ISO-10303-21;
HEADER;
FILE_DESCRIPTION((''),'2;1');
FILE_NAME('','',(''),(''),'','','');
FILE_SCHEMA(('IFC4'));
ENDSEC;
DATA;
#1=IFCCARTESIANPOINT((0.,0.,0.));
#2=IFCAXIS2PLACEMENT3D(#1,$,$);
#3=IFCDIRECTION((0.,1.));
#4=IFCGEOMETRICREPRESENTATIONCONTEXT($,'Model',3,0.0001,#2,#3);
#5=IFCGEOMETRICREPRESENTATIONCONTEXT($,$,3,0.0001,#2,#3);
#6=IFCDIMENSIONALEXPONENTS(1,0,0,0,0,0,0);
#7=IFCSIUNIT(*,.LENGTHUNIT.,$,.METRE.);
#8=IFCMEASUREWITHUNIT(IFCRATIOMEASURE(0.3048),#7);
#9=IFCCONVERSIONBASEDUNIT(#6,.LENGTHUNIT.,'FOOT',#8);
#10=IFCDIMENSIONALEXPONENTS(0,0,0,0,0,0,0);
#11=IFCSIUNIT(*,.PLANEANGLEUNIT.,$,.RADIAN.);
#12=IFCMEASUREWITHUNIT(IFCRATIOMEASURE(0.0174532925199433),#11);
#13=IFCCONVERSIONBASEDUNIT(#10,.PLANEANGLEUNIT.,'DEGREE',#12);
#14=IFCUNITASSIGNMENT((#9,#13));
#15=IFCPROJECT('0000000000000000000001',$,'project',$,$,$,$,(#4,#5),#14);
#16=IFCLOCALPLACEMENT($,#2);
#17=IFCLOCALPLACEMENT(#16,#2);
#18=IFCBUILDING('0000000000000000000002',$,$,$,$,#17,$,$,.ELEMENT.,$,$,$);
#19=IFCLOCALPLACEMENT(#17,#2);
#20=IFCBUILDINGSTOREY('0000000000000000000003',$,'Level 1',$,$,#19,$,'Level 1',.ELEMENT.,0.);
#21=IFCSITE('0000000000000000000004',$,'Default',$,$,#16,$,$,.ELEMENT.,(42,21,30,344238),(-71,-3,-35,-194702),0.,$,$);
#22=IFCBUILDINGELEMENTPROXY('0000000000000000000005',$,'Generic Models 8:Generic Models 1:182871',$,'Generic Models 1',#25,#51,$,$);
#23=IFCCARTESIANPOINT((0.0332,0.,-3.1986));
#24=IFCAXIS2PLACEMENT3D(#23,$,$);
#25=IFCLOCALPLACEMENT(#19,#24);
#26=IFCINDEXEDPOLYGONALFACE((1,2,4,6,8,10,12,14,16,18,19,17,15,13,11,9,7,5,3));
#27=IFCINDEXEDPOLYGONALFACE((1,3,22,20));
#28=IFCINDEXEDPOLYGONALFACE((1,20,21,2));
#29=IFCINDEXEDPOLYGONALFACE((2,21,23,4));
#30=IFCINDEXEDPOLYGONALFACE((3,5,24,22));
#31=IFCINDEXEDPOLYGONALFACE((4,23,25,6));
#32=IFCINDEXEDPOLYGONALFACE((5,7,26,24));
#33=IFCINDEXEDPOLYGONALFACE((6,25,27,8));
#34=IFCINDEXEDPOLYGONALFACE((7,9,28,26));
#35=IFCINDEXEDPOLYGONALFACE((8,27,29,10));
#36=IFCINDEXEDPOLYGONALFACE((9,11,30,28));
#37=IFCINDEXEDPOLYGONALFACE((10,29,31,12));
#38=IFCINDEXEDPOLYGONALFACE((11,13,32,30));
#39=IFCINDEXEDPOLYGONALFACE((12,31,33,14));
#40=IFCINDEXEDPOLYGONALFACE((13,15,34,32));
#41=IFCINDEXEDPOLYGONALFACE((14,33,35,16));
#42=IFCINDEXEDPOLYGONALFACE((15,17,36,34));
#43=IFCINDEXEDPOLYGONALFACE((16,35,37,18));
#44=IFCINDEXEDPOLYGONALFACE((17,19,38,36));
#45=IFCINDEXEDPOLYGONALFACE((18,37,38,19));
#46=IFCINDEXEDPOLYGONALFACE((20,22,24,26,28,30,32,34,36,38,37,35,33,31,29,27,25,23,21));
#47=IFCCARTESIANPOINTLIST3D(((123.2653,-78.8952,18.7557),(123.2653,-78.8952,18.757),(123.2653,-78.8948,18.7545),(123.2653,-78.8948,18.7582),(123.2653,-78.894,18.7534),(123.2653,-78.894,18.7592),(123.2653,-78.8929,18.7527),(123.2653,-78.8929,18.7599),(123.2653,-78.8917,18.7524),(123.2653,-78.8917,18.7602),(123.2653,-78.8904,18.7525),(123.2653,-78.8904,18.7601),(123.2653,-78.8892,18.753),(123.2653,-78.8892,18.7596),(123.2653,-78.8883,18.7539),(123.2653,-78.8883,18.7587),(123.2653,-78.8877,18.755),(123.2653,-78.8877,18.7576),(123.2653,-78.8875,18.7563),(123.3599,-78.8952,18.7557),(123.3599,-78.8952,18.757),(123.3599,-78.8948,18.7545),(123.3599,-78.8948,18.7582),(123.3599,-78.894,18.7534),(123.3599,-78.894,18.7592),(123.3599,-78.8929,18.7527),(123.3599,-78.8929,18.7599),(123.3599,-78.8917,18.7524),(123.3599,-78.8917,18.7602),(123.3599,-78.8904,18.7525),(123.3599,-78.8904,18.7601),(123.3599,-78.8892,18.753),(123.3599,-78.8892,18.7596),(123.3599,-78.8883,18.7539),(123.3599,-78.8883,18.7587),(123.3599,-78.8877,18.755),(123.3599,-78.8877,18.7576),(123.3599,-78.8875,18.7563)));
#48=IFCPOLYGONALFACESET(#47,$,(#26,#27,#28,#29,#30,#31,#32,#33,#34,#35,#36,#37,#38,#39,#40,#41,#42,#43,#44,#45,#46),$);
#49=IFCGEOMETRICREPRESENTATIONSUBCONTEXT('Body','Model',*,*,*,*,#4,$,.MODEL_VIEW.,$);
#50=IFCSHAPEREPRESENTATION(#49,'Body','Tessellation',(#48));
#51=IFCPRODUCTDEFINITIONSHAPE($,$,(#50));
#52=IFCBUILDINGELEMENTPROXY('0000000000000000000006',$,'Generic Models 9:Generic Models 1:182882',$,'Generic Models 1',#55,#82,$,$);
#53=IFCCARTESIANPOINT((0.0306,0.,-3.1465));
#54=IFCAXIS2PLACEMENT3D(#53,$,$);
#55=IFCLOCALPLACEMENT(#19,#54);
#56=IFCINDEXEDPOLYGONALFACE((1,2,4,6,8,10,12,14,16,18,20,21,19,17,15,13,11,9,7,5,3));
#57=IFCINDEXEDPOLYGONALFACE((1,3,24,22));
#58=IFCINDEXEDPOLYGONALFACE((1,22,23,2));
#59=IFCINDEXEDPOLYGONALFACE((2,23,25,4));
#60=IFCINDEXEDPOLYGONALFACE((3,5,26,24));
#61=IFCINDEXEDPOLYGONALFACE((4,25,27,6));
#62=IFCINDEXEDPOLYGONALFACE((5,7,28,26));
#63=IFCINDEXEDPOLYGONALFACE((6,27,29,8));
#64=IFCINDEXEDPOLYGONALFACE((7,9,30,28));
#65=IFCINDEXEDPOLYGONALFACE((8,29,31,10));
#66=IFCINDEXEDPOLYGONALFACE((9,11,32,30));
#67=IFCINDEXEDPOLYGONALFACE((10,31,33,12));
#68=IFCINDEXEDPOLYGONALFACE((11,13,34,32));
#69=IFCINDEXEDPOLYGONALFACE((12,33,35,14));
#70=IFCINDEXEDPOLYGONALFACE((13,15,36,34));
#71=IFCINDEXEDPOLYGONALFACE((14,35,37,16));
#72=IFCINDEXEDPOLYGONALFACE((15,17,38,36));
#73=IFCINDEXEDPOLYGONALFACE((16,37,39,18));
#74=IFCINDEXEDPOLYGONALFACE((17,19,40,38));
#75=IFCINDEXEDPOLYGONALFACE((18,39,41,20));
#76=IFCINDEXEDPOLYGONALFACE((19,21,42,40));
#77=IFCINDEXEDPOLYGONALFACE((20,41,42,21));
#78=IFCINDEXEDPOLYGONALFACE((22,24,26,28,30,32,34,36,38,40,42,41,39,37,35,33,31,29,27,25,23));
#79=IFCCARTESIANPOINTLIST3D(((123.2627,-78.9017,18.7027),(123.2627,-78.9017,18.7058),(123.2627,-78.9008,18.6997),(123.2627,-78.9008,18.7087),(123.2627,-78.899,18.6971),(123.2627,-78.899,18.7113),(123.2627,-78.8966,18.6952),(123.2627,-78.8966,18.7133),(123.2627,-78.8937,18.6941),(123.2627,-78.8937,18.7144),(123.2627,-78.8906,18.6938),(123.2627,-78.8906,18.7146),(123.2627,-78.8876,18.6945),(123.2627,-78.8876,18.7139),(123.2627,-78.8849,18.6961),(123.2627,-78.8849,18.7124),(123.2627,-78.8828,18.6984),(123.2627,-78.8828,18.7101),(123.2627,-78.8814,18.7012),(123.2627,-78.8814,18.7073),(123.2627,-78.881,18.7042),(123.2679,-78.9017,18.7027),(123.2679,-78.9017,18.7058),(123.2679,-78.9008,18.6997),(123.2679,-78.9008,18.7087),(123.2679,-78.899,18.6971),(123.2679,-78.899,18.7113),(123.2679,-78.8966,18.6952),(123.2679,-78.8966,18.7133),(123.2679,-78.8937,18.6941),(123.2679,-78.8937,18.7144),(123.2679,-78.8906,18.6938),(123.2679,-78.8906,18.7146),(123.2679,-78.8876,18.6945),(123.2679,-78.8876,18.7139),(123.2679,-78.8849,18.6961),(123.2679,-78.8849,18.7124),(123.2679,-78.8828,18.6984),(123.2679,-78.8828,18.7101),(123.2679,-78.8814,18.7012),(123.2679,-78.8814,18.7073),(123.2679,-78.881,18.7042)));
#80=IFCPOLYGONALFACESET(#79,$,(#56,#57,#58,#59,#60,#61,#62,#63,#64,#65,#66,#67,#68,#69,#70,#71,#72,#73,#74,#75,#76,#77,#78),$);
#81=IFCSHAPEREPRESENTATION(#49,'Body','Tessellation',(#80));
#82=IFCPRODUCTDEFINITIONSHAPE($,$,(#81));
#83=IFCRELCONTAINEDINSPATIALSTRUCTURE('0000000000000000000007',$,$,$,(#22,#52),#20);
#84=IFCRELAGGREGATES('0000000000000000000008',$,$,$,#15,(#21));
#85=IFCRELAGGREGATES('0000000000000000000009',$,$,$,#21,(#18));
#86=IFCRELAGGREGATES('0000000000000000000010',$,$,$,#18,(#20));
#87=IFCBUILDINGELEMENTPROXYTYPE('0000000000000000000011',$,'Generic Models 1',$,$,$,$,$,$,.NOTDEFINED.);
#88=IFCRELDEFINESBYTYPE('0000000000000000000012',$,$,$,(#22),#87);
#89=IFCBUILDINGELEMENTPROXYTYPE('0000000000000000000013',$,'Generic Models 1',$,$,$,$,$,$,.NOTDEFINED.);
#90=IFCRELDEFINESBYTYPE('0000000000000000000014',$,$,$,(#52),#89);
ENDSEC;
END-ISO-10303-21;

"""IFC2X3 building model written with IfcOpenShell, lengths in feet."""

from ifc_helpers import new_model, entity, si_unit, converted_unit, direction, frame, origin, origin_2d_with_axis, place, context, subcontext, project, spatial, circle, extrude, source, transform, mapped, type_object, type_shapes, element, save


model = new_model("IFC2X3")

# Units and contexts
model_context = context("Model", 3, precision=0.0001, world=origin(), true_north=direction((0.0, 1.0)))
context_of_model = context(None, 3, precision=0.0001, world=origin(), true_north=direction((0.0, 1.0)))
body_context = subcontext(model_context, "Body", "Model", "MODEL_VIEW")
ifc_project = project(units=[converted_unit("LENGTHUNIT", "FOOT", entity("IfcRatioMeasure", 0.3048), si_unit("LENGTHUNIT", "METRE"), dimensions=[1, 0, 0, 0, 0, 0, 0]), converted_unit("PLANEANGLEUNIT", "DEGREE", entity("IfcRatioMeasure", 0.0174532925199433), si_unit("PLANEANGLEUNIT", "RADIAN"), dimensions=[0, 0, 0, 0, 0, 0, 0])], contexts=[model_context, context_of_model])

# Site, building, storey
site_placement = place(None, origin())
site = spatial("IfcSite", under=ifc_project, at=site_placement, Name="Default", CompositionType="ELEMENT", RefLatitude=(42, 21, 30, 344238), RefLongitude=(-71, -3, -35, -194702), RefElevation=0.0)
building_placement = place(site_placement, origin())
building = spatial("IfcBuilding", under=site, at=building_placement, CompositionType="ELEMENT")
storey_placement = place(building_placement, origin())
storey = spatial("IfcBuildingStorey", under=building, at=storey_placement, Name="Level 1", LongName="Level 1", CompositionType="ELEMENT", Elevation=0.0)

# Building element proxies
building_element_proxy_type_1 = type_object("IfcBuildingElementProxyType", Name="Generic Models 1", PredefinedType="NOTDEFINED")
shared_shape_1 = source(origin(), body_context, "Body", "SweptSolid", [
    extrude(circle(Radius=0.0039, at=origin_2d_with_axis()), frame((123.2653, -78.8914, 18.7563), z_axis=(1.0, 0.0, 0.0), x_axis=(0.0, 1.0, 0.0)), (0.0, 0.0, 1.0), 0.0945),
])
type_shapes(building_element_proxy_type_1, [shared_shape_1])
proxy_1_placement = place(storey_placement, frame((0.0332, 0.0, -3.1986)))
element("IfcBuildingElementProxy", 1, at=proxy_1_placement, inside=storey, type_object=building_element_proxy_type_1, Name="Generic Models 8:Generic Models 1:182871", ObjectType="Generic Models 1", context=body_context, shape_type="MappedRepresentation", body=[
    mapped(shared_shape_1, transform((0.0, 0.0, 0.0), scale=1.0)),
])
building_element_proxy_type_2 = type_object("IfcBuildingElementProxyType", Name="Generic Models 1", PredefinedType="NOTDEFINED")
shared_shape_2 = source(origin(), body_context, "Body", "SweptSolid", [
    extrude(circle(Radius=0.0104, at=origin_2d_with_axis()), frame((123.2627, -78.8914, 18.7042), z_axis=(1.0, 0.0, 0.0), x_axis=(0.0, 1.0, 0.0)), (0.0, 0.0, 1.0), 0.0052),
])
type_shapes(building_element_proxy_type_2, [shared_shape_2])
proxy_2_placement = place(storey_placement, frame((0.0306, 0.0, -3.1465)))
element("IfcBuildingElementProxy", 2, at=proxy_2_placement, inside=storey, type_object=building_element_proxy_type_2, Name="Generic Models 9:Generic Models 1:182882", ObjectType="Generic Models 1", context=body_context, shape_type="MappedRepresentation", body=[
    mapped(shared_shape_2, transform((0.0, 0.0, 0.0), scale=1.0)),
])

save(model, "model.ifc")
